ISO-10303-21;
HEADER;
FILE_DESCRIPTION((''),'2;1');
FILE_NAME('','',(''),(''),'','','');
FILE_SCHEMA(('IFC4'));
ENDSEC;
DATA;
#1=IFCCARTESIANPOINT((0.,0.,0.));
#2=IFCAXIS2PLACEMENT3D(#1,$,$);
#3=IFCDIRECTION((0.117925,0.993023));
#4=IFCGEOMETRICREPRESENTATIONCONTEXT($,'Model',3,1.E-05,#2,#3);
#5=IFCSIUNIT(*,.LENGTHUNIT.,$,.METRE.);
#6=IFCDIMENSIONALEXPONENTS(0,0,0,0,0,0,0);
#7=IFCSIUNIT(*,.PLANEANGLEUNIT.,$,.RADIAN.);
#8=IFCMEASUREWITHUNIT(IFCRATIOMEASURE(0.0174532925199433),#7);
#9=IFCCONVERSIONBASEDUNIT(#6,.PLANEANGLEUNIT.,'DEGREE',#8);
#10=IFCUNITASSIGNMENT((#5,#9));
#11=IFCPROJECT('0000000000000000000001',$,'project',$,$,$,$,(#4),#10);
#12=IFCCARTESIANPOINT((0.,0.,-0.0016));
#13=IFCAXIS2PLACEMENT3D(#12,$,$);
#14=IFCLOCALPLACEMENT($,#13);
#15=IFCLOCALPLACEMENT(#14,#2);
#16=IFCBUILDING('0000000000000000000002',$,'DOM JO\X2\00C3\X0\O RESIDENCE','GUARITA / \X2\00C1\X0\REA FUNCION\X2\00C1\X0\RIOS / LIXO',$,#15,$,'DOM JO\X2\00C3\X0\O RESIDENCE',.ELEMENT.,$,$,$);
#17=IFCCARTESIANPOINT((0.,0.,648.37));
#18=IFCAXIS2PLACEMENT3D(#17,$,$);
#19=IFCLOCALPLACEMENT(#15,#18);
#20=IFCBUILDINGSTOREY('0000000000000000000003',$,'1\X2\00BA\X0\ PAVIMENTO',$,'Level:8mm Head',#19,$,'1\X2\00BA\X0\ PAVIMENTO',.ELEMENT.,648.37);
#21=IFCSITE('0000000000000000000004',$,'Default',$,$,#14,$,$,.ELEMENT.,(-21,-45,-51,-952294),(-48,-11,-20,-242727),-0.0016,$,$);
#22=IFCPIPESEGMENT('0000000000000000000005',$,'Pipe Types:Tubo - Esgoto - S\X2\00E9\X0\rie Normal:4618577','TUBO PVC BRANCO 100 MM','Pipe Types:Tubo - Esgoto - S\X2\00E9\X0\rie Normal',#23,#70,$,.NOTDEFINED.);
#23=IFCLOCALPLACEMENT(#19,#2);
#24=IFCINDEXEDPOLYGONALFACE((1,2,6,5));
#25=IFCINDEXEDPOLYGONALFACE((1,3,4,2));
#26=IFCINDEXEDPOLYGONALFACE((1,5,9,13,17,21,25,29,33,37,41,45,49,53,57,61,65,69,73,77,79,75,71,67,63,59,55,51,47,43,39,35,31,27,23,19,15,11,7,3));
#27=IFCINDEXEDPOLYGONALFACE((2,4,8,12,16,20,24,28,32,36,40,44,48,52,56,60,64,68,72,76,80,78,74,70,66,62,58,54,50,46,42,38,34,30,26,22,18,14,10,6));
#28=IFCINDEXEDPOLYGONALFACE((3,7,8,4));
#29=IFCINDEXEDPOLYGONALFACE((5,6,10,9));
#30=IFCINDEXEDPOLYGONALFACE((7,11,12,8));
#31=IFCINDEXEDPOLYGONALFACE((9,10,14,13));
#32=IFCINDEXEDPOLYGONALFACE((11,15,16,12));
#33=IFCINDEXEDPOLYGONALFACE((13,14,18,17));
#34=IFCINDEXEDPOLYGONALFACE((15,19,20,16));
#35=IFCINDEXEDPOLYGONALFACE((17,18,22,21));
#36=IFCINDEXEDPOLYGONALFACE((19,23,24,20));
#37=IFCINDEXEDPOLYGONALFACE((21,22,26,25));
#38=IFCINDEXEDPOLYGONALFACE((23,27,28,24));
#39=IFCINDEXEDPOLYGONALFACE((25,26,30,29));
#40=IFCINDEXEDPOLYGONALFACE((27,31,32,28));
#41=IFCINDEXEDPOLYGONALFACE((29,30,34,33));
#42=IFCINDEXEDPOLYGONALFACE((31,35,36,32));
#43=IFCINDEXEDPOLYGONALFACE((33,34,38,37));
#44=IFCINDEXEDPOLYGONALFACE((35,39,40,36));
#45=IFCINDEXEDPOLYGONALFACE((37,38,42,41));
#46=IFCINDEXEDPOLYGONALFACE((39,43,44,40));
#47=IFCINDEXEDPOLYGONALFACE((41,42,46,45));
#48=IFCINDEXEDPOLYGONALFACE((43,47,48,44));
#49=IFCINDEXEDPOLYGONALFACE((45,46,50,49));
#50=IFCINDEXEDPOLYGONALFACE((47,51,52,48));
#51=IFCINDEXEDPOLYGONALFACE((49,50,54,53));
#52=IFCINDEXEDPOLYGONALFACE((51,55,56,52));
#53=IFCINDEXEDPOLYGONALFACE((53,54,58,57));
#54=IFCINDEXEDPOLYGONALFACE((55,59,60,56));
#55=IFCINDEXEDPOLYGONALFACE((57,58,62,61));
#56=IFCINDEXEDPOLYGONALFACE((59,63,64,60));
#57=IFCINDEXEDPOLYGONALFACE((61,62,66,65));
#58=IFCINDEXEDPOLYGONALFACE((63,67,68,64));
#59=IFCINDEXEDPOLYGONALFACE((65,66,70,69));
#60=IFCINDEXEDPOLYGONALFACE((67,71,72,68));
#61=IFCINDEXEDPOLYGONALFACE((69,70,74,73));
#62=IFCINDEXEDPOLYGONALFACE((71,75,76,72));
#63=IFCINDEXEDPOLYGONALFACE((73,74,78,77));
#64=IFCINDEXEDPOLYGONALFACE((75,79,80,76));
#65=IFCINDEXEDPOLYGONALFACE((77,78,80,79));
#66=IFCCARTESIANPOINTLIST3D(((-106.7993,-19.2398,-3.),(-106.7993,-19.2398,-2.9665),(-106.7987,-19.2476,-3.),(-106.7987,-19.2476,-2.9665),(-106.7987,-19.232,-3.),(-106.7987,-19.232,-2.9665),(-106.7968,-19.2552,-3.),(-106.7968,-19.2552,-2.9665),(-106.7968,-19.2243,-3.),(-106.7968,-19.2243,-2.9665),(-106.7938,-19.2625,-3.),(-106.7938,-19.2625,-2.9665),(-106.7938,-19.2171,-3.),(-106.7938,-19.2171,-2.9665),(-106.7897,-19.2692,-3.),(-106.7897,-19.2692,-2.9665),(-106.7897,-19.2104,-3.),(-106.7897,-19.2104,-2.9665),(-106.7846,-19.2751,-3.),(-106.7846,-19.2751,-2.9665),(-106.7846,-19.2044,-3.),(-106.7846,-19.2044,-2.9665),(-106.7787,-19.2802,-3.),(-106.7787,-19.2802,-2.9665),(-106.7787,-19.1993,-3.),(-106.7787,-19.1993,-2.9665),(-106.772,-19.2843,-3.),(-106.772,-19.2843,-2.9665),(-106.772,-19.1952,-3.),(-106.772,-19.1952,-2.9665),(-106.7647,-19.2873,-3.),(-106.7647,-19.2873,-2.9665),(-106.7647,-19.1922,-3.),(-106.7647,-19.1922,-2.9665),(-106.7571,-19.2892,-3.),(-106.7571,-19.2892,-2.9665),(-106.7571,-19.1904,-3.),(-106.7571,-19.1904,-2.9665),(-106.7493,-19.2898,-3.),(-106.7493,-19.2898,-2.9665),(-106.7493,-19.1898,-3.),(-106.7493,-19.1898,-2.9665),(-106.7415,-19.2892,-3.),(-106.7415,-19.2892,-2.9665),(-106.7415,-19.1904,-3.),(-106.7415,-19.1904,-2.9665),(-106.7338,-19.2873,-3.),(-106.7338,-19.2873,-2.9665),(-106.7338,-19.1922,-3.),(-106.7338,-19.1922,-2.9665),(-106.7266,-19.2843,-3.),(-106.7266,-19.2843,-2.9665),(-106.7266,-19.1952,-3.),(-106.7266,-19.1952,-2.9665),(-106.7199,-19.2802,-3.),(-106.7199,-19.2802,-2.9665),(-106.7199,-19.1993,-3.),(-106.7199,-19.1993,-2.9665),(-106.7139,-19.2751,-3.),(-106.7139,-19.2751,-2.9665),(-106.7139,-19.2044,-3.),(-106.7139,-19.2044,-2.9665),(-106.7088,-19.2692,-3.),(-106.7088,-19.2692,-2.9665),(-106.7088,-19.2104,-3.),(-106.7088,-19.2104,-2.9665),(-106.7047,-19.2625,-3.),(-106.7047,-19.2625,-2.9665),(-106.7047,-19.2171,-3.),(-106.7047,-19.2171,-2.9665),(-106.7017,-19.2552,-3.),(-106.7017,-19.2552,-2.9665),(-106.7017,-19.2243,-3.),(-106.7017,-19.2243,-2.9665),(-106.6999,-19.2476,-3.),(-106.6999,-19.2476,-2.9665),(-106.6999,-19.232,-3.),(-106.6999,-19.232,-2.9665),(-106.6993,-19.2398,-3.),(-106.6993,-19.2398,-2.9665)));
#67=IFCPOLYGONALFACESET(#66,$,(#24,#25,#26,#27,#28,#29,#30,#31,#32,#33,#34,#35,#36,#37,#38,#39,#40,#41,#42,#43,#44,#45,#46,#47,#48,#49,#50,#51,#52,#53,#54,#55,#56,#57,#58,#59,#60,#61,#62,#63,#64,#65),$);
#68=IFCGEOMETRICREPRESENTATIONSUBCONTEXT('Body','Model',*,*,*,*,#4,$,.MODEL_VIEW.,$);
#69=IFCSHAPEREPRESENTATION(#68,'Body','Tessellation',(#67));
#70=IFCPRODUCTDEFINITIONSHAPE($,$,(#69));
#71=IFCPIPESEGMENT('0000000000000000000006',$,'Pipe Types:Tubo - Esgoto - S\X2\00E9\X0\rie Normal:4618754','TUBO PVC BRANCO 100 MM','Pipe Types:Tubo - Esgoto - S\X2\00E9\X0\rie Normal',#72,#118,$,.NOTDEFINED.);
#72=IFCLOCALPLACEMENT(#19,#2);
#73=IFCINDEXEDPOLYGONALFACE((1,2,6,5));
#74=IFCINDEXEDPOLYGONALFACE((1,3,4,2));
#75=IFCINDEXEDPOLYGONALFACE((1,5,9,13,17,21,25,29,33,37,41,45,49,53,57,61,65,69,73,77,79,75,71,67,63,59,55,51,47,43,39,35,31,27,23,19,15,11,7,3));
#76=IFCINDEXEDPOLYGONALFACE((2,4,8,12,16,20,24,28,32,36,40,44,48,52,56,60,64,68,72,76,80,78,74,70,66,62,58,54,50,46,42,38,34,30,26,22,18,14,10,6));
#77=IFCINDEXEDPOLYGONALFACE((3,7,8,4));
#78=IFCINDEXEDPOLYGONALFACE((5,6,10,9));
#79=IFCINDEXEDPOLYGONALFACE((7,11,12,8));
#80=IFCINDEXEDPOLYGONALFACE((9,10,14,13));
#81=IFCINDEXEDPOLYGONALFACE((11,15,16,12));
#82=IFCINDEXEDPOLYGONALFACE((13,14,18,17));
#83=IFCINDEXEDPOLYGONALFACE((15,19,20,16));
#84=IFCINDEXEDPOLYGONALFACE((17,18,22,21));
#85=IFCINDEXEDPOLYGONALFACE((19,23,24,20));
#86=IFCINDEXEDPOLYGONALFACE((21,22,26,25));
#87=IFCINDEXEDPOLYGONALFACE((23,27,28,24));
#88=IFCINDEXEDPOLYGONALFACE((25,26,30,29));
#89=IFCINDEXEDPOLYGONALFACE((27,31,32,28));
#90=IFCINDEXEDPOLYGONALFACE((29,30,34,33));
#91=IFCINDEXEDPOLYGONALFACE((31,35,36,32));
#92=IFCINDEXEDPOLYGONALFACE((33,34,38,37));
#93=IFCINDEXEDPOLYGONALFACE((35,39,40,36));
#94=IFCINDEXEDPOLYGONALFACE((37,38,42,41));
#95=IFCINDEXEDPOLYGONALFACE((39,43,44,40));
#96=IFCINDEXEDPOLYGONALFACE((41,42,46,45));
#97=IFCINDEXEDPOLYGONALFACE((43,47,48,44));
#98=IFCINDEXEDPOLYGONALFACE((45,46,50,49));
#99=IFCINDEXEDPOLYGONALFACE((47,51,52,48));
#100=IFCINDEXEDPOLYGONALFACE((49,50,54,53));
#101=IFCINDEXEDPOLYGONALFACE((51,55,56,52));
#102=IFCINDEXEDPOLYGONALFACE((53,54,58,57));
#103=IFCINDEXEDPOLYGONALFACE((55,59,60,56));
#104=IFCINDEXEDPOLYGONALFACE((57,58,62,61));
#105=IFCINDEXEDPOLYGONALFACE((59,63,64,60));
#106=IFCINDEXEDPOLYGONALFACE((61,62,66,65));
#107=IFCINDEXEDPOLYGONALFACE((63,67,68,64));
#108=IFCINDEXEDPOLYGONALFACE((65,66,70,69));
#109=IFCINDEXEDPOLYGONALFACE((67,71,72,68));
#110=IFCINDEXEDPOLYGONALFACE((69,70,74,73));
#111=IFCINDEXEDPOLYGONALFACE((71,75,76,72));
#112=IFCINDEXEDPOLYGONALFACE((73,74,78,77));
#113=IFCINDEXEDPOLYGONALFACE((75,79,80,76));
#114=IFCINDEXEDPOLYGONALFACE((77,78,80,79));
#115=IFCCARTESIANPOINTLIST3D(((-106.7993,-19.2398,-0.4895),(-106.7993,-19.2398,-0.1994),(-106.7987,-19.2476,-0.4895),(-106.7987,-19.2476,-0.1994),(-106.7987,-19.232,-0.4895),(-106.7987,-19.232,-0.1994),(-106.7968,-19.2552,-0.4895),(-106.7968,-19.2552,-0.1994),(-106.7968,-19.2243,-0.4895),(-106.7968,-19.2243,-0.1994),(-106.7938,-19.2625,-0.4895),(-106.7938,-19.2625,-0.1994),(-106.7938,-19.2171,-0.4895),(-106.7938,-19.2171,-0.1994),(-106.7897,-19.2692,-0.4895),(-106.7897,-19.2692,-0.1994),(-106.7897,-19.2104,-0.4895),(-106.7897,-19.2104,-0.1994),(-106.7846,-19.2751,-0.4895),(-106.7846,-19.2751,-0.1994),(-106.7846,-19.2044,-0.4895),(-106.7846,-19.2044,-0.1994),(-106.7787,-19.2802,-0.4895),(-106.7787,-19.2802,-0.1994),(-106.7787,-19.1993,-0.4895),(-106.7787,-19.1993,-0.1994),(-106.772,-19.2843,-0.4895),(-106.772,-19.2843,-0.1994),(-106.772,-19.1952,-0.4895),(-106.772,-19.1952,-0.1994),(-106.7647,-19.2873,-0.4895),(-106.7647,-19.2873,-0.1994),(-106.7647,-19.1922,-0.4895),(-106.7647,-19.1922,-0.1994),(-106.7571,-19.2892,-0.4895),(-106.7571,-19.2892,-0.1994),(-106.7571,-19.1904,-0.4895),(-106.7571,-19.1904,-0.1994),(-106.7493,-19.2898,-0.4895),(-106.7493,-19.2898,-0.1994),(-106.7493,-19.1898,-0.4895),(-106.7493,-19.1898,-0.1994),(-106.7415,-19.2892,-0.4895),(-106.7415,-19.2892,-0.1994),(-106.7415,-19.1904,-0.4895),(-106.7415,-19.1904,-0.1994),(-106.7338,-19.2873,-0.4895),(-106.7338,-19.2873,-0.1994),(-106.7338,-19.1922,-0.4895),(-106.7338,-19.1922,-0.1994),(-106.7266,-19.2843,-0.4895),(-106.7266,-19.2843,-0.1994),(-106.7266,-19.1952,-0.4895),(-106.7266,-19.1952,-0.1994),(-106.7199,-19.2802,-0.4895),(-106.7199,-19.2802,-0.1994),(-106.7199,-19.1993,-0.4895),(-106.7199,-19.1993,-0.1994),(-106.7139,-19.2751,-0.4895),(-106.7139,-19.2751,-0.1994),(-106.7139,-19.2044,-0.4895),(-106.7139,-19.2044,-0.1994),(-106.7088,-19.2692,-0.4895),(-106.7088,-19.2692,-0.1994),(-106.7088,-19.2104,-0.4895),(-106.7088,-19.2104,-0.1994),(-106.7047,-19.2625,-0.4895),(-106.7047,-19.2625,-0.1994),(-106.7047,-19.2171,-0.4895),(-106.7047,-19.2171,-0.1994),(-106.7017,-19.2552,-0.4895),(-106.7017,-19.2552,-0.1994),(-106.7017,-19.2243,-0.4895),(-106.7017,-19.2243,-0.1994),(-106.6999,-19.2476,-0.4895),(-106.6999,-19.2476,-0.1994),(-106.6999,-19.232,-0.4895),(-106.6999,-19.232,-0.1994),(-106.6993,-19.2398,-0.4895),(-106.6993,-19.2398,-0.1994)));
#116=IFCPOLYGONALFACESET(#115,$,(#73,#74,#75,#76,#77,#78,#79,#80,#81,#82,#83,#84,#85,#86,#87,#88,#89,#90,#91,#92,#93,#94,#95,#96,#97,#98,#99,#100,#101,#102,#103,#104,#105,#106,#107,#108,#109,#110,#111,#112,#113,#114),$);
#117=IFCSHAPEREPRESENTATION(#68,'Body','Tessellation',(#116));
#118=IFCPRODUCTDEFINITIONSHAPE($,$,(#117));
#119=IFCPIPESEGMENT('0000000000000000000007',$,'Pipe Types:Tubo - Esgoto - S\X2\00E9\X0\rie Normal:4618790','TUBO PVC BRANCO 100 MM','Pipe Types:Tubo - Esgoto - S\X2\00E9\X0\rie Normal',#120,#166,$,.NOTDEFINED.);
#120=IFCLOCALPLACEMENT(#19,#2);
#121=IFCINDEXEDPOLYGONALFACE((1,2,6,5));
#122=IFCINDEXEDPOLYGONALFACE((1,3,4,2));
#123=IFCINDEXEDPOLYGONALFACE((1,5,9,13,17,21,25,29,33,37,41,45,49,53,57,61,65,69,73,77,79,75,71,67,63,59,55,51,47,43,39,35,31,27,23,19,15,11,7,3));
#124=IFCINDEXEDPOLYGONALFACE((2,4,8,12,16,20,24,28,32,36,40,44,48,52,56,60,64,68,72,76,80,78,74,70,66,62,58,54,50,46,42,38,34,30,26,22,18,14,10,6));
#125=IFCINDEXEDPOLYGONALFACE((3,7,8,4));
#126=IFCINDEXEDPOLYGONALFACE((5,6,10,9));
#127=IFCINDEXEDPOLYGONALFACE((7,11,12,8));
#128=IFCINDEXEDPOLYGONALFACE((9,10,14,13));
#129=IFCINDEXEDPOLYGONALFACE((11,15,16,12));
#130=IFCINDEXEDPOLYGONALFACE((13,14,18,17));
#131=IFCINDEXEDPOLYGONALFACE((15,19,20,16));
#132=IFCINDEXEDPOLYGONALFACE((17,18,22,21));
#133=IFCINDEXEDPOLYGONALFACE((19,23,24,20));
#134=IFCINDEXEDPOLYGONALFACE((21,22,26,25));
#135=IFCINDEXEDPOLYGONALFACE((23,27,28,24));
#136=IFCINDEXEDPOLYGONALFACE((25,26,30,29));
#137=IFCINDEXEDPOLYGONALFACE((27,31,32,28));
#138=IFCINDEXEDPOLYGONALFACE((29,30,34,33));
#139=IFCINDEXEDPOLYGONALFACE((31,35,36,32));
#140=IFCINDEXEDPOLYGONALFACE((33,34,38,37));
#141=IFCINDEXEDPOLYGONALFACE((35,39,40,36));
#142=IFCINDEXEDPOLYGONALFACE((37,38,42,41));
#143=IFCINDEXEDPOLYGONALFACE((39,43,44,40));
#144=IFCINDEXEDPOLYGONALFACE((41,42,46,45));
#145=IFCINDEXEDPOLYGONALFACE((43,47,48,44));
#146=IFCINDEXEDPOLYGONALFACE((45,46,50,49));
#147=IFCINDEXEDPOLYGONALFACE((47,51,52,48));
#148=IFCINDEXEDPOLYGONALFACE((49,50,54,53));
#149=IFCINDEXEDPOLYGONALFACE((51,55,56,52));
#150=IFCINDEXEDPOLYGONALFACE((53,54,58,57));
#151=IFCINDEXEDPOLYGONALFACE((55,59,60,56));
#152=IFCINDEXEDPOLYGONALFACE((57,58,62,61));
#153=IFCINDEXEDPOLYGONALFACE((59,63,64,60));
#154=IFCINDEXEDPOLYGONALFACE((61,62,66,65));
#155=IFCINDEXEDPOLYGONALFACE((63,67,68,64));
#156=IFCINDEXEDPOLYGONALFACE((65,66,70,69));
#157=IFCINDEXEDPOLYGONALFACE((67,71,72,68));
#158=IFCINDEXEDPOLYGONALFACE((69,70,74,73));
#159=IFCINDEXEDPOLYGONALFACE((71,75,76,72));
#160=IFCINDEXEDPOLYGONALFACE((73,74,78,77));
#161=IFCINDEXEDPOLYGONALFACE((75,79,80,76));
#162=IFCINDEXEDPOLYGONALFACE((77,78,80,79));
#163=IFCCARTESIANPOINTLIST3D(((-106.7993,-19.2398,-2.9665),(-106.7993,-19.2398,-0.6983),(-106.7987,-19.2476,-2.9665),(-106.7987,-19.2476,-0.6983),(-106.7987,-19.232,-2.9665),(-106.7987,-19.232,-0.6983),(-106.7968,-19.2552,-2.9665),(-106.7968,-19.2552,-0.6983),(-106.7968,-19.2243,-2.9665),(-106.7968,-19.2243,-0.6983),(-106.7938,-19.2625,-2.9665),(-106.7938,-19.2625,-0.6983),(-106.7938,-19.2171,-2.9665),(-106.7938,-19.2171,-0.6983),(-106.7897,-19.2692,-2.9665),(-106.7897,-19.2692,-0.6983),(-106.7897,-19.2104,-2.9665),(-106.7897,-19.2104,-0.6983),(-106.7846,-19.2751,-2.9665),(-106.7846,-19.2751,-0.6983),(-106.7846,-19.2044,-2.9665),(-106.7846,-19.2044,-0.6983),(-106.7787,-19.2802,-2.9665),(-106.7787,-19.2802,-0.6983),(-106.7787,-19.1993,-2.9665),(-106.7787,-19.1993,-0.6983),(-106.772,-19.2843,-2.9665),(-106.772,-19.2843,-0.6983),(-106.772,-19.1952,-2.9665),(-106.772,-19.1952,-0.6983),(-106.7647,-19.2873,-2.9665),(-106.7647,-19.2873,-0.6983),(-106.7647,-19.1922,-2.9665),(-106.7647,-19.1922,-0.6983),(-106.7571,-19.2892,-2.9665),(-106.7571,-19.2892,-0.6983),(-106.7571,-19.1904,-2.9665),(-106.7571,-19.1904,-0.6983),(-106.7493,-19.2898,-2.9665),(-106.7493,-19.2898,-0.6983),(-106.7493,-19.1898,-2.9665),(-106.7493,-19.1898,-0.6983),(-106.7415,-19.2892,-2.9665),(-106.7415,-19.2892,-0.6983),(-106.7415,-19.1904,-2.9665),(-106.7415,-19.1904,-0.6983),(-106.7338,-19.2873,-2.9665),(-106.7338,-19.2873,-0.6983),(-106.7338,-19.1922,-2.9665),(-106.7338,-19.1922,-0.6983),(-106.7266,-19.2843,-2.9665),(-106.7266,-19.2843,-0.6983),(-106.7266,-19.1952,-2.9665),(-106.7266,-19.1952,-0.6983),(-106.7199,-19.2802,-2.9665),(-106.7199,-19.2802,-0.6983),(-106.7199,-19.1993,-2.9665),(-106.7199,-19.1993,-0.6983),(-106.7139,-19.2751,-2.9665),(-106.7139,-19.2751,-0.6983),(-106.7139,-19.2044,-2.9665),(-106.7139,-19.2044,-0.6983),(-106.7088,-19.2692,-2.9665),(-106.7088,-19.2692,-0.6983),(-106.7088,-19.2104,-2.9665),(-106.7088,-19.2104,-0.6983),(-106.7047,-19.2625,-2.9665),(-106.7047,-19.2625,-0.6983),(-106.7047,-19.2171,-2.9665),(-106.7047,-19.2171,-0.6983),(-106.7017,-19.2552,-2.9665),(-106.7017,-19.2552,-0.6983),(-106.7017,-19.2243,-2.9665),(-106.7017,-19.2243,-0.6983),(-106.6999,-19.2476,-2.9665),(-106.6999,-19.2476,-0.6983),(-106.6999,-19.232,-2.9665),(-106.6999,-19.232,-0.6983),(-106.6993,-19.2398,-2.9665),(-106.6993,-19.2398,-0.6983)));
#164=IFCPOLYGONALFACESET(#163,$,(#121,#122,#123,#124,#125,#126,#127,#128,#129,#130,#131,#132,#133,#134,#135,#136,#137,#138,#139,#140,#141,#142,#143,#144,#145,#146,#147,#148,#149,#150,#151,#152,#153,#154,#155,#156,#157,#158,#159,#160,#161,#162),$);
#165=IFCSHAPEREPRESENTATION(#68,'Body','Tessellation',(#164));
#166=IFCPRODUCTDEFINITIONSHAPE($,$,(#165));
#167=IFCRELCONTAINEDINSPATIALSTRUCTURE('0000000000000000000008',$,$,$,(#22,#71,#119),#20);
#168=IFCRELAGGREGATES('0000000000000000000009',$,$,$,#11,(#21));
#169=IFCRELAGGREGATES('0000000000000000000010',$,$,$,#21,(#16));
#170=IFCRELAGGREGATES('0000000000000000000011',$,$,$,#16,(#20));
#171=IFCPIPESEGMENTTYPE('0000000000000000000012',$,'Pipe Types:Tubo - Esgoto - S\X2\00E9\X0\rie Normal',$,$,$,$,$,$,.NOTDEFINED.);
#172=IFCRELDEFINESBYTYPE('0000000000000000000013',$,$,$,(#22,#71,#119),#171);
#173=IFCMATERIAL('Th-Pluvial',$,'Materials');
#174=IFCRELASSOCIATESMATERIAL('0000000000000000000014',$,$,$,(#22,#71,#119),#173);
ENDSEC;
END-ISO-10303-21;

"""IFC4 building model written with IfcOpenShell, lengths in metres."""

from ifc_helpers import new_model, entity, si_unit, converted_unit, direction, frame, origin, place, context, subcontext, project, spatial, indexed_curve, outline, extrude, material, type_object, element, save


model = new_model("IFC4")

# Units and contexts
model_context = context("Model", 3, precision=1e-05, world=origin(), true_north=direction((0.117925, 0.993023)))
body_context = subcontext(model_context, "Body", "Model", "MODEL_VIEW")
ifc_project = project(units=[si_unit("LENGTHUNIT", "METRE"), converted_unit("PLANEANGLEUNIT", "DEGREE", entity("IfcRatioMeasure", 0.0174532925199433), si_unit("PLANEANGLEUNIT", "RADIAN"), dimensions=[0, 0, 0, 0, 0, 0, 0])], contexts=[model_context])

# Site, building, storey
site_placement = place(None, frame((0.0, 0.0, -0.0016)))
site = spatial("IfcSite", under=ifc_project, at=site_placement, Name="Default", CompositionType="ELEMENT", RefLatitude=(-21, -45, -51, -952294), RefLongitude=(-48, -11, -20, -242727), RefElevation=-0.0016)
building_placement = place(site_placement, origin())
building = spatial("IfcBuilding", under=site, at=building_placement, Name="DOM JOÃO RESIDENCE", Description="GUARITA / ÁREA FUNCIONÁRIOS / LIXO", LongName="DOM JOÃO RESIDENCE", CompositionType="ELEMENT")
storey_placement = place(building_placement, frame((0.0, 0.0, 648.37)))
storey = spatial("IfcBuildingStorey", under=building, at=storey_placement, Name="1º PAVIMENTO", ObjectType="Level:8mm Head", LongName="1º PAVIMENTO", CompositionType="ELEMENT", Elevation=648.37)

# Pipe segments
ifc_material = material(Name="Th-Pluvial", Category="Materials")
pipe_segment_type = type_object("IfcPipeSegmentType", Name="Pipe Types:Tubo - Esgoto - Série Normal", PredefinedType="NOTDEFINED")
pipe_segment_1_placement = place(storey_placement, frame((-106.8009, -19.2914, -3.0)))
element("IfcPipeSegment", 1, at=pipe_segment_1_placement, inside=storey, type_object=pipe_segment_type, material=ifc_material, Name="Pipe Types:Tubo - Esgoto - Série Normal:4618577", Description="TUBO PVC BRANCO 100 MM", ObjectType="Pipe Types:Tubo - Esgoto - Série Normal", PredefinedType="NOTDEFINED", context=body_context, shape_type="SweptSolid", body=[
    extrude(outline(indexed_curve([(0.05, 0.0), (0.0494, 0.0078), (0.0476, 0.0155), (0.0446, 0.0227), (0.0405, 0.0294), (0.0354, 0.0354), (0.0294, 0.0405), (0.0227, 0.0446), (0.0155, 0.0476), (0.0078, 0.0494), (0.0, 0.05), (-0.0078, 0.0494), (-0.0155, 0.0476), (-0.0227, 0.0446), (-0.0294, 0.0405), (-0.0354, 0.0354), (-0.0405, 0.0294), (-0.0446, 0.0227), (-0.0476, 0.0155), (-0.0494, 0.0078), (-0.05, 0.0), (-0.0494, -0.0078), (-0.0476, -0.0155), (-0.0446, -0.0227), (-0.0405, -0.0294), (-0.0354, -0.0354), (-0.0294, -0.0405), (-0.0227, -0.0446), (-0.0155, -0.0476), (-0.0078, -0.0494), (0.0, -0.05), (0.0078, -0.0494), (0.0155, -0.0476), (0.0227, -0.0446), (0.0294, -0.0405), (0.0354, -0.0354), (0.0405, -0.0294), (0.0446, -0.0227), (0.0476, -0.0155), (0.0494, -0.0078), (0.05, 0.0)], self_intersect=False)), frame((0.0516, 0.0516, 0.0)), (0.0, 0.0, 1.0), 0.0335),
])
pipe_segment_2_placement = place(storey_placement, frame((-106.8009, -19.2914, -0.4895)))
element("IfcPipeSegment", 2, at=pipe_segment_2_placement, inside=storey, type_object=pipe_segment_type, material=ifc_material, Name="Pipe Types:Tubo - Esgoto - Série Normal:4618754", Description="TUBO PVC BRANCO 100 MM", ObjectType="Pipe Types:Tubo - Esgoto - Série Normal", PredefinedType="NOTDEFINED", context=body_context, shape_type="SweptSolid", body=[
    extrude(outline(indexed_curve([(0.05, 0.0), (0.0494, 0.0078), (0.0476, 0.0155), (0.0446, 0.0227), (0.0405, 0.0294), (0.0354, 0.0354), (0.0294, 0.0405), (0.0227, 0.0446), (0.0155, 0.0476), (0.0078, 0.0494), (0.0, 0.05), (-0.0078, 0.0494), (-0.0155, 0.0476), (-0.0227, 0.0446), (-0.0294, 0.0405), (-0.0354, 0.0354), (-0.0405, 0.0294), (-0.0446, 0.0227), (-0.0476, 0.0155), (-0.0494, 0.0078), (-0.05, 0.0), (-0.0494, -0.0078), (-0.0476, -0.0155), (-0.0446, -0.0227), (-0.0405, -0.0294), (-0.0354, -0.0354), (-0.0294, -0.0405), (-0.0227, -0.0446), (-0.0155, -0.0476), (-0.0078, -0.0494), (0.0, -0.05), (0.0078, -0.0494), (0.0155, -0.0476), (0.0227, -0.0446), (0.0294, -0.0405), (0.0354, -0.0354), (0.0405, -0.0294), (0.0446, -0.0227), (0.0476, -0.0155), (0.0494, -0.0078), (0.05, 0.0)], self_intersect=False)), frame((0.0516, 0.0516, 0.0)), (0.0, 0.0, 1.0), 0.2901),
])
pipe_segment_3_placement = place(storey_placement, frame((-106.8009, -19.2914, -2.9665)))
element("IfcPipeSegment", 3, at=pipe_segment_3_placement, inside=storey, type_object=pipe_segment_type, material=ifc_material, Name="Pipe Types:Tubo - Esgoto - Série Normal:4618790", Description="TUBO PVC BRANCO 100 MM", ObjectType="Pipe Types:Tubo - Esgoto - Série Normal", PredefinedType="NOTDEFINED", context=body_context, shape_type="SweptSolid", body=[
    extrude(outline(indexed_curve([(0.05, 0.0), (0.0494, 0.0078), (0.0476, 0.0155), (0.0446, 0.0227), (0.0405, 0.0294), (0.0354, 0.0354), (0.0294, 0.0405), (0.0227, 0.0446), (0.0155, 0.0476), (0.0078, 0.0494), (0.0, 0.05), (-0.0078, 0.0494), (-0.0155, 0.0476), (-0.0227, 0.0446), (-0.0294, 0.0405), (-0.0354, 0.0354), (-0.0405, 0.0294), (-0.0446, 0.0227), (-0.0476, 0.0155), (-0.0494, 0.0078), (-0.05, 0.0), (-0.0494, -0.0078), (-0.0476, -0.0155), (-0.0446, -0.0227), (-0.0405, -0.0294), (-0.0354, -0.0354), (-0.0294, -0.0405), (-0.0227, -0.0446), (-0.0155, -0.0476), (-0.0078, -0.0494), (0.0, -0.05), (0.0078, -0.0494), (0.0155, -0.0476), (0.0227, -0.0446), (0.0294, -0.0405), (0.0354, -0.0354), (0.0405, -0.0294), (0.0446, -0.0227), (0.0476, -0.0155), (0.0494, -0.0078), (0.05, 0.0)], self_intersect=False)), frame((0.0516, 0.0516, 0.0)), (0.0, 0.0, 1.0), 2.2682),
])

save(model, "model.ifc")
